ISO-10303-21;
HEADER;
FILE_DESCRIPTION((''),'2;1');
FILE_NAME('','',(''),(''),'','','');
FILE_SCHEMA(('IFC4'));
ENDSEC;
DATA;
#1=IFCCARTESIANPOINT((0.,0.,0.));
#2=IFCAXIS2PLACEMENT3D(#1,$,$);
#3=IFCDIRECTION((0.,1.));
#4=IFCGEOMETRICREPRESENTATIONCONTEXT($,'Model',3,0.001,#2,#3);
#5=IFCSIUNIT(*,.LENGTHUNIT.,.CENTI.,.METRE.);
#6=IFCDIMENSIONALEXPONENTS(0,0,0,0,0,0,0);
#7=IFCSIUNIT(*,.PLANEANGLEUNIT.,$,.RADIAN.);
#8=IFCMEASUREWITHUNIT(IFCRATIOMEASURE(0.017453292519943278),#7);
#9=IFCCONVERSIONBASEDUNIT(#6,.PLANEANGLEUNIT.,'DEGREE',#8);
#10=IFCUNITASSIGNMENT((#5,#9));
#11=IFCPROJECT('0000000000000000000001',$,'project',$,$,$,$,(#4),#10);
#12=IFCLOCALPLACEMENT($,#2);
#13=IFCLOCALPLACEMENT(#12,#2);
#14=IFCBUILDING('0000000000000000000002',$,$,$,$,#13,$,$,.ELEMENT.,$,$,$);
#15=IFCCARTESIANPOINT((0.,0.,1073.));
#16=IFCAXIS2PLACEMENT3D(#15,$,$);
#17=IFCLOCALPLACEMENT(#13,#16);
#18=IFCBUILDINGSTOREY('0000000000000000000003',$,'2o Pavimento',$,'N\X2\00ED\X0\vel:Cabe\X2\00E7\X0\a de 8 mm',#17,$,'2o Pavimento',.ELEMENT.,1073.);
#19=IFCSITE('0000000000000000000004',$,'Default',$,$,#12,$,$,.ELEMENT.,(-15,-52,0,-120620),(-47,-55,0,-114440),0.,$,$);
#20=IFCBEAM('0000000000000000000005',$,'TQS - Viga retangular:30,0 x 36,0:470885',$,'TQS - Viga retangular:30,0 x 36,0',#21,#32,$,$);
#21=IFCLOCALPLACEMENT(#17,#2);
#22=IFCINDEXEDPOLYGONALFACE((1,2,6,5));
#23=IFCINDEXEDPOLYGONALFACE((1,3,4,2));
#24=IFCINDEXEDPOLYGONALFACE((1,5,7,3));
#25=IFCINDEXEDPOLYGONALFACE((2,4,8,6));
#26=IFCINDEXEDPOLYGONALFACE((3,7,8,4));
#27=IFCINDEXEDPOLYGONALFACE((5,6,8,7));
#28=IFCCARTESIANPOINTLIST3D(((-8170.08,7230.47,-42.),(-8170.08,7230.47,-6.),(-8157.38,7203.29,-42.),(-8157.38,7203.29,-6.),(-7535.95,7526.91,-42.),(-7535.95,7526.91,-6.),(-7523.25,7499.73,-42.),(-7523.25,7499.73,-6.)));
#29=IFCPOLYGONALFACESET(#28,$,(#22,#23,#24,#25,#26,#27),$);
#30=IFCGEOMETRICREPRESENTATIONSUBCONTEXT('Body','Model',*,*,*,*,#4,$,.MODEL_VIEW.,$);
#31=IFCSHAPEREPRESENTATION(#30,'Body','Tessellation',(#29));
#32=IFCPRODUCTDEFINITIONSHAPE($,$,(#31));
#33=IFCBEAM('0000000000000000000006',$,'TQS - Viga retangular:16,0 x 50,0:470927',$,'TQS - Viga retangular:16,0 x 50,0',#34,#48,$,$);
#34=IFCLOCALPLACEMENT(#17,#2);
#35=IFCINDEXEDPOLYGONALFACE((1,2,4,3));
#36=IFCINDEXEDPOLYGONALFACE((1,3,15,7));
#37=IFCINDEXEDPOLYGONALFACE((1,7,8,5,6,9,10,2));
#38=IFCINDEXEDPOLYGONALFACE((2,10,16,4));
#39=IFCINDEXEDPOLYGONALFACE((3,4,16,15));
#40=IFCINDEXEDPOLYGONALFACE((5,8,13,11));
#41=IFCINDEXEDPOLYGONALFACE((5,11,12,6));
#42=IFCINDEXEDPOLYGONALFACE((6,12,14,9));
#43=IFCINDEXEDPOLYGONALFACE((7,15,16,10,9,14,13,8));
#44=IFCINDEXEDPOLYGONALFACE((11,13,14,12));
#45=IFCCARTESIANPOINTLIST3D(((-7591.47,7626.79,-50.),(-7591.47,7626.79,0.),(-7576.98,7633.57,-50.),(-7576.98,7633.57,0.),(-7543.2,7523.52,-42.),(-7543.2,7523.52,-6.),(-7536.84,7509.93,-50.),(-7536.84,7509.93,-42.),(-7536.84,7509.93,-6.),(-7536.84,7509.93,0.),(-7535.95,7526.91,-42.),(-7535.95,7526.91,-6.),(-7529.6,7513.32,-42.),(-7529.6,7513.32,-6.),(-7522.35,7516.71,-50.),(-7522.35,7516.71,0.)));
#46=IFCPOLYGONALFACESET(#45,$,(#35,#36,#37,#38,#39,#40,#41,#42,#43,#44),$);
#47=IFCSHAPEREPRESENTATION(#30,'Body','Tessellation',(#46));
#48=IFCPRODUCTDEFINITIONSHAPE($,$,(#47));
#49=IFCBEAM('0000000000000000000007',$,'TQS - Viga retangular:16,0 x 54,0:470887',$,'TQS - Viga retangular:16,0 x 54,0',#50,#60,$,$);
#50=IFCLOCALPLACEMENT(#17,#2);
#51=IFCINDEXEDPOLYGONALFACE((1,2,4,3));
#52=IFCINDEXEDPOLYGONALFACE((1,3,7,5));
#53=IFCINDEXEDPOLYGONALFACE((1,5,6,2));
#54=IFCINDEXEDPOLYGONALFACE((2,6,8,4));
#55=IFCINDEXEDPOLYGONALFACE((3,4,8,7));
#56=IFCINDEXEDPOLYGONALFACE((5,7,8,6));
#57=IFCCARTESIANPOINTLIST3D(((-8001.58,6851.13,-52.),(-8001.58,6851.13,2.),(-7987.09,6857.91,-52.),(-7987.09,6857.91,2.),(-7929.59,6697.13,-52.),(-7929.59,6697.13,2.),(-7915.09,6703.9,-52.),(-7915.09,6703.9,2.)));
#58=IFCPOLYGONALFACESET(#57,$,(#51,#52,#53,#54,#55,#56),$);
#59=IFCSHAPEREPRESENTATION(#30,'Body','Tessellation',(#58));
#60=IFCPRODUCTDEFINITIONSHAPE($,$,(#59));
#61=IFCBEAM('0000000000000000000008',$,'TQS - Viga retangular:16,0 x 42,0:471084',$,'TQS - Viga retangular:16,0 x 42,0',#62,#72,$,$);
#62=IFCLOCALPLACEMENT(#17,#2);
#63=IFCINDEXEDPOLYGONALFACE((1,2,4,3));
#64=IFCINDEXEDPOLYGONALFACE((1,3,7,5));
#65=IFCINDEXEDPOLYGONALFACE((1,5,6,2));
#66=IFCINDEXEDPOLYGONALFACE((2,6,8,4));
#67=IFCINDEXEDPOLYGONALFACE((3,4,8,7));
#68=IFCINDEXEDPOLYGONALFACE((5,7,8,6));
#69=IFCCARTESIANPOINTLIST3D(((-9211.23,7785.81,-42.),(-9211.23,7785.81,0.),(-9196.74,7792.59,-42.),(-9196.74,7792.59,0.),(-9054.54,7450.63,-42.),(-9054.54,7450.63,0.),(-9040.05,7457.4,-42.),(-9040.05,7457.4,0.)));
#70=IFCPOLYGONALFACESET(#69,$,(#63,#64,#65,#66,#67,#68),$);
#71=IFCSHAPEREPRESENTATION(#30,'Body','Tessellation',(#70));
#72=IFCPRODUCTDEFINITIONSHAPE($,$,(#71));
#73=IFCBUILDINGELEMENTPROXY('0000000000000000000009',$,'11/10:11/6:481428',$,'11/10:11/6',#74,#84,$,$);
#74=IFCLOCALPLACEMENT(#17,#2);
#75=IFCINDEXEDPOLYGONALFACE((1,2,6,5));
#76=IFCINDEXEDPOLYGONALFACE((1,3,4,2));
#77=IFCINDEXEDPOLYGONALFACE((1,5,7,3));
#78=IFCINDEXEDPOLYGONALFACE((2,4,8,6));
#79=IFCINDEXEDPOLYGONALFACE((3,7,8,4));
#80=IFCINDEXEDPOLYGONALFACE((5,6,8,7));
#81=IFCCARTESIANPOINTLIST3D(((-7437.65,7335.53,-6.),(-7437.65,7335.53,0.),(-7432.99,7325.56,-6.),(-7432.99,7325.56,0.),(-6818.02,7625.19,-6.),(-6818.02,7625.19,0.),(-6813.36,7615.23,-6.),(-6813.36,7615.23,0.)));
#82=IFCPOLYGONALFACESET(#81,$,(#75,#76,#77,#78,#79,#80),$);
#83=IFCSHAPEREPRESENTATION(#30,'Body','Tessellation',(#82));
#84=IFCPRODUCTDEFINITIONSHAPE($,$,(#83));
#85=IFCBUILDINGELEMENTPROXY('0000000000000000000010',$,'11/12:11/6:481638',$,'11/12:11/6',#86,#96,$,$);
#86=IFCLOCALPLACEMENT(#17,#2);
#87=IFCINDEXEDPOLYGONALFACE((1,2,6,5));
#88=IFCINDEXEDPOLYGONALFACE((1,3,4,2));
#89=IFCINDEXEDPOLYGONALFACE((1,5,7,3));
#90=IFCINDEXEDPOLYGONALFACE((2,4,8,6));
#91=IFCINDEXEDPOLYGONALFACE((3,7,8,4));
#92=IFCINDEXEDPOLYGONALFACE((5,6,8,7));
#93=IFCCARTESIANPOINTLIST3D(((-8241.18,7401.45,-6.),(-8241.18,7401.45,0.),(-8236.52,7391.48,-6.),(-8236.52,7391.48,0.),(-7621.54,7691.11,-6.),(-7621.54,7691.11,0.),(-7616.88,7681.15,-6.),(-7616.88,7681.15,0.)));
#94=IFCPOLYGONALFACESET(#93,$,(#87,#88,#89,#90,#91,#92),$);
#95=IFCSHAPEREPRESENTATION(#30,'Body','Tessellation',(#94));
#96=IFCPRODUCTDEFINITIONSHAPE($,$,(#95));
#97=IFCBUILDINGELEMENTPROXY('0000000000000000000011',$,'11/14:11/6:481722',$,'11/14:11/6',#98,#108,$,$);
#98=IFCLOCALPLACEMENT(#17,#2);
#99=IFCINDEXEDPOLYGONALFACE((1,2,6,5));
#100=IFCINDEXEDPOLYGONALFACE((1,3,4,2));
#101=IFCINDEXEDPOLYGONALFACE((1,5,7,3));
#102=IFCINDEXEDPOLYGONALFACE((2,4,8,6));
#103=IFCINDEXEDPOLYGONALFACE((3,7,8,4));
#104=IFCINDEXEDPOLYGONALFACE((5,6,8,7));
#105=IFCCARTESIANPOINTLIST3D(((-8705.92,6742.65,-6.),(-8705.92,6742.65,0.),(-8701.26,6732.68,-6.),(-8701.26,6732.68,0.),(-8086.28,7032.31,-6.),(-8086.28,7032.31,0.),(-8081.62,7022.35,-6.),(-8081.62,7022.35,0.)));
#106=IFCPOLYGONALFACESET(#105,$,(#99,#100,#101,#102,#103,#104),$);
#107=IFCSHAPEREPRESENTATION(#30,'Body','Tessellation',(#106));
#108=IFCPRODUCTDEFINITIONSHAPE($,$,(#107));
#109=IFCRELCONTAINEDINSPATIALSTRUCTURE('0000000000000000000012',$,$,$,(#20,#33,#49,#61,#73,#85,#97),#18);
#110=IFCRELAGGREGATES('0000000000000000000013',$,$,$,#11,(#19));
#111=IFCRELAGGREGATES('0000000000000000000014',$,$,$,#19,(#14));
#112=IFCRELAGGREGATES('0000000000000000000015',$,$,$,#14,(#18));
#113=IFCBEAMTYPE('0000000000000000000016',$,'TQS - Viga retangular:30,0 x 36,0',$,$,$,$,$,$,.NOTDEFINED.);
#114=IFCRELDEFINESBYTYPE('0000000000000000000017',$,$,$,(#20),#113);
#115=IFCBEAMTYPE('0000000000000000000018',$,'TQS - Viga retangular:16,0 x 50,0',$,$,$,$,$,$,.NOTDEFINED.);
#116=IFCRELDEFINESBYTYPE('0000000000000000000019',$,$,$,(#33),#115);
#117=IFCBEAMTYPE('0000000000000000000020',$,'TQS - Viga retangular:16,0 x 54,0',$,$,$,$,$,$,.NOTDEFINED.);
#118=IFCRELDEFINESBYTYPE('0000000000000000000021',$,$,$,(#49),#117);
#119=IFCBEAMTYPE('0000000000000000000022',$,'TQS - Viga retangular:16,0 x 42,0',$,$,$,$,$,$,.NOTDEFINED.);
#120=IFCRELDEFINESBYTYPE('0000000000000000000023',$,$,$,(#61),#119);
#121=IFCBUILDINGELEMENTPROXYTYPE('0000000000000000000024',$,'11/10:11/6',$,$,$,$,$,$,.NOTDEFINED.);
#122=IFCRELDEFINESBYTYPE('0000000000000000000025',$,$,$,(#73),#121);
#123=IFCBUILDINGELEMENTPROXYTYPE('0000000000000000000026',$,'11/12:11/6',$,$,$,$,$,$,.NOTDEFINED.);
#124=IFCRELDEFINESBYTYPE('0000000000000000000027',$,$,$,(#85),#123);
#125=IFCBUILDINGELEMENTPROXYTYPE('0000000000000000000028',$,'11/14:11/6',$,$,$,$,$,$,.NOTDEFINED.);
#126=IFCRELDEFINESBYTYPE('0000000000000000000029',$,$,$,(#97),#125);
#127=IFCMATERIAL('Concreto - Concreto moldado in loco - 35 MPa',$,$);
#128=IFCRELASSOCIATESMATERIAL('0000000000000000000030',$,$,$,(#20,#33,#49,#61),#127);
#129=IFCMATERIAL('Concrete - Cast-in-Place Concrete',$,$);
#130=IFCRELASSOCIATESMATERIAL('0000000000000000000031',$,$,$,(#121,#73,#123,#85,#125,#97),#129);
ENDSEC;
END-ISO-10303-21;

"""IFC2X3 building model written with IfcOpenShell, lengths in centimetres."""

from ifc_helpers import new_model, entity, si_unit, converted_unit, direction, frame, frame_2d, origin, place, context, subcontext, project, spatial, polyline, rectangle, extrude, boolean, clip, bounded_halfspace, source, transform, mapped, material, type_object, type_shapes, element, save


model = new_model("IFC2X3")

# Units and contexts
model_context = context("Model", 3, precision=0.001, world=origin(), true_north=direction((0.0, 1.0)))
body_context = subcontext(model_context, "Body", "Model", "MODEL_VIEW")
ifc_project = project(units=[si_unit("LENGTHUNIT", "METRE", prefix="CENTI"), converted_unit("PLANEANGLEUNIT", "DEGREE", entity("IfcRatioMeasure", 0.017453292519943278), si_unit("PLANEANGLEUNIT", "RADIAN"), dimensions=[0, 0, 0, 0, 0, 0, 0])], contexts=[model_context])

# Site, building, storey
site_placement = place(None, origin())
site = spatial("IfcSite", under=ifc_project, at=site_placement, Name="Default", CompositionType="ELEMENT", RefLatitude=(-15, -52, 0, -120620), RefLongitude=(-47, -55, 0, -114440), RefElevation=0.0)
building_placement = place(site_placement, origin())
building = spatial("IfcBuilding", under=site, at=building_placement, CompositionType="ELEMENT")
storey_placement = place(building_placement, frame((0.0, 0.0, 1073.0)))
storey = spatial("IfcBuildingStorey", under=building, at=storey_placement, Name="2o Pavimento", ObjectType="Nível:Cabeça de 8 mm", LongName="2o Pavimento", CompositionType="ELEMENT", Elevation=1073.0)

# Beams
ifc_material_1 = material(Name="Concreto - Concreto moldado in loco - 35 MPa")
beam_type_1 = type_object("IfcBeamType", Name="TQS - Viga retangular:30,0 x 36,0", PredefinedType="NOTDEFINED")
beam_1_placement = place(storey_placement, frame((-8163.73, 7216.88, -6.0), z_axis=(0.0, 0.0, 1.0), x_axis=(0.905902, 0.423488, 0.0)))
element("IfcBeam", 1, at=beam_1_placement, inside=storey, type_object=beam_type_1, material=ifc_material_1, Name="TQS - Viga retangular:30,0 x 36,0:470885", ObjectType="TQS - Viga retangular:30,0 x 36,0", context=body_context, shape_type="SweptSolid", body=[
    extrude(rectangle(XDim=36.0, YDim=30.0, at=frame_2d((0.0, 0.0), x_axis=(1.0, 0.0))), frame((0.0, 0.0, -18.0), z_axis=(1.0, 0.0, 0.0), x_axis=(0.0, 0.0, -1.0)), (0.0, 0.0, 1.0), 700.0),
])
beam_type_2 = type_object("IfcBeamType", Name="TQS - Viga retangular:16,0 x 50,0", PredefinedType="NOTDEFINED")
beam_2_placement = place(storey_placement, frame((-7529.6, 7513.32, 0.0), z_axis=(0.0, 0.0, 1.0), x_axis=(-0.423488, 0.905902, 0.0)))
element("IfcBeam", 2, at=beam_2_placement, inside=storey, type_object=beam_type_2, material=ifc_material_1, Name="TQS - Viga retangular:16,0 x 50,0:470927", ObjectType="TQS - Viga retangular:16,0 x 50,0", context=body_context, shape_type="SweptSolid", body=[
    boolean("DIFFERENCE", clip(extrude(rectangle(XDim=50.0, YDim=16.0, at=frame_2d((0.0, 0.0), x_axis=(1.0, 0.0))), frame((0.0, 0.0, -25.0), z_axis=(1.0, 0.0, 0.0), x_axis=(0.0, 0.0, -1.0)), (0.0, 0.0, 1.0), 129.0), bounded_halfspace(frame((15.0, 0.0, -42.0), z_axis=(-1.0, 0.0, 0.0), x_axis=(0.0, 1.0, 0.0)), False, frame((0.0, 0.0, -25.0), z_axis=(1.0, 0.0, 0.0), x_axis=(0.0, 0.0, -1.0)), polyline([(17.0, 0.0), (-19.0, 0.0), (-19.0, 8.0), (-9.0, 8.0), (17.0, 8.0), (17.0, 0.0)]))), extrude(rectangle(XDim=36.0, YDim=8.0, at=frame_2d((0.0, 0.0), x_axis=(0.0, 1.0))), frame((0.0, 4.0, -24.0), z_axis=(-1.0, 0.0, 0.0), x_axis=(0.0, -1.0, 0.0)), (0.0, 0.0, -1.0), 15.0)),
])
beam_type_3 = type_object("IfcBeamType", Name="TQS - Viga retangular:16,0 x 54,0", PredefinedType="NOTDEFINED")
beam_3_placement = place(storey_placement, frame((-7922.34, 6700.52, 2.0), z_axis=(0.0, 0.0, 1.0), x_axis=(-0.423488, 0.905902, 0.0)))
element("IfcBeam", 3, at=beam_3_placement, inside=storey, type_object=beam_type_3, material=ifc_material_1, Name="TQS - Viga retangular:16,0 x 54,0:470887", ObjectType="TQS - Viga retangular:16,0 x 54,0", context=body_context, shape_type="SweptSolid", body=[
    extrude(rectangle(XDim=54.0, YDim=16.0, at=frame_2d((0.0, 0.0), x_axis=(1.0, 0.0))), frame((0.0, 0.0, -27.0), z_axis=(1.0, 0.0, 0.0), x_axis=(0.0, 0.0, -1.0)), (0.0, 0.0, 1.0), 170.0),
])
beam_type_4 = type_object("IfcBeamType", Name="TQS - Viga retangular:16,0 x 42,0", PredefinedType="NOTDEFINED")
beam_4_placement = place(storey_placement, frame((-9043.91, 7446.77, 0.0), z_axis=(0.0, 0.0, 1.0), x_axis=(-0.423488, 0.905902, 0.0)))
element("IfcBeam", 4, at=beam_4_placement, inside=storey, type_object=beam_type_4, material=ifc_material_1, Name="TQS - Viga retangular:16,0 x 42,0:471084", ObjectType="TQS - Viga retangular:16,0 x 42,0", context=body_context, shape_type="SweptSolid", body=[
    extrude(rectangle(XDim=42.0, YDim=16.0, at=frame_2d((0.0, 0.0), x_axis=(1.0, 0.0))), frame((8.0, 0.0, -21.0), z_axis=(1.0, 0.0, 0.0), x_axis=(0.0, 0.0, -1.0)), (0.0, 0.0, 1.0), 370.0),
])

# Building element proxies
ifc_material_2 = material(Name="Concrete - Cast-in-Place Concrete")
building_element_proxy_type_1 = type_object("IfcBuildingElementProxyType", Name="11/10:11/6", PredefinedType="NOTDEFINED", material=ifc_material_2)
shared_shape_1 = source(origin(), body_context, "Body", "SweptSolid", [
    extrude(rectangle(XDim=11.0, YDim=684.0, at=frame_2d((0.0, 0.0), x_axis=(1.0, 0.0))), frame((312.15, 149.82, 0.0), z_axis=(0.0, 0.0, 1.0), x_axis=(0.423488, -0.905902, 0.0)), (0.0, 0.0, 1.0), 6.0),
])
type_shapes(building_element_proxy_type_1, [shared_shape_1])
proxy_1_placement = place(storey_placement, frame((-7437.65, 7325.56, -6.0)))
element("IfcBuildingElementProxy", 5, at=proxy_1_placement, inside=storey, type_object=building_element_proxy_type_1, material=ifc_material_2, Name="11/10:11/6:481428", ObjectType="11/10:11/6", context=body_context, shape_type="MappedRepresentation", body=[
    mapped(shared_shape_1, transform((0.0, 0.0, 0.0), scale=1.0)),
])
building_element_proxy_type_2 = type_object("IfcBuildingElementProxyType", Name="11/12:11/6", PredefinedType="NOTDEFINED", material=ifc_material_2)
shared_shape_2 = source(origin(), body_context, "Body", "SweptSolid", [
    extrude(rectangle(XDim=11.0, YDim=684.0, at=frame_2d((0.0, 0.0), x_axis=(1.0, 0.0))), frame((312.15, 149.82, 0.0), z_axis=(0.0, 0.0, 1.0), x_axis=(0.423488, -0.905902, 0.0)), (0.0, 0.0, 1.0), 6.0),
])
type_shapes(building_element_proxy_type_2, [shared_shape_2])
proxy_2_placement = place(storey_placement, frame((-8241.18, 7391.48, -6.0)))
element("IfcBuildingElementProxy", 6, at=proxy_2_placement, inside=storey, type_object=building_element_proxy_type_2, material=ifc_material_2, Name="11/12:11/6:481638", ObjectType="11/12:11/6", context=body_context, shape_type="MappedRepresentation", body=[
    mapped(shared_shape_2, transform((0.0, 0.0, 0.0), scale=1.0)),
])
building_element_proxy_type_3 = type_object("IfcBuildingElementProxyType", Name="11/14:11/6", PredefinedType="NOTDEFINED", material=ifc_material_2)
shared_shape_3 = source(origin(), body_context, "Body", "SweptSolid", [
    extrude(rectangle(XDim=11.0, YDim=684.0, at=frame_2d((0.0, 0.0), x_axis=(1.0, 0.0))), frame((312.15, 149.82, 0.0), z_axis=(0.0, 0.0, 1.0), x_axis=(0.423488, -0.905902, 0.0)), (0.0, 0.0, 1.0), 6.0),
])
type_shapes(building_element_proxy_type_3, [shared_shape_3])
proxy_3_placement = place(storey_placement, frame((-8705.92, 6732.68, -6.0)))
element("IfcBuildingElementProxy", 7, at=proxy_3_placement, inside=storey, type_object=building_element_proxy_type_3, material=ifc_material_2, Name="11/14:11/6:481722", ObjectType="11/14:11/6", context=body_context, shape_type="MappedRepresentation", body=[
    mapped(shared_shape_3, transform((0.0, 0.0, 0.0), scale=1.0)),
])

save(model, "model.ifc")
